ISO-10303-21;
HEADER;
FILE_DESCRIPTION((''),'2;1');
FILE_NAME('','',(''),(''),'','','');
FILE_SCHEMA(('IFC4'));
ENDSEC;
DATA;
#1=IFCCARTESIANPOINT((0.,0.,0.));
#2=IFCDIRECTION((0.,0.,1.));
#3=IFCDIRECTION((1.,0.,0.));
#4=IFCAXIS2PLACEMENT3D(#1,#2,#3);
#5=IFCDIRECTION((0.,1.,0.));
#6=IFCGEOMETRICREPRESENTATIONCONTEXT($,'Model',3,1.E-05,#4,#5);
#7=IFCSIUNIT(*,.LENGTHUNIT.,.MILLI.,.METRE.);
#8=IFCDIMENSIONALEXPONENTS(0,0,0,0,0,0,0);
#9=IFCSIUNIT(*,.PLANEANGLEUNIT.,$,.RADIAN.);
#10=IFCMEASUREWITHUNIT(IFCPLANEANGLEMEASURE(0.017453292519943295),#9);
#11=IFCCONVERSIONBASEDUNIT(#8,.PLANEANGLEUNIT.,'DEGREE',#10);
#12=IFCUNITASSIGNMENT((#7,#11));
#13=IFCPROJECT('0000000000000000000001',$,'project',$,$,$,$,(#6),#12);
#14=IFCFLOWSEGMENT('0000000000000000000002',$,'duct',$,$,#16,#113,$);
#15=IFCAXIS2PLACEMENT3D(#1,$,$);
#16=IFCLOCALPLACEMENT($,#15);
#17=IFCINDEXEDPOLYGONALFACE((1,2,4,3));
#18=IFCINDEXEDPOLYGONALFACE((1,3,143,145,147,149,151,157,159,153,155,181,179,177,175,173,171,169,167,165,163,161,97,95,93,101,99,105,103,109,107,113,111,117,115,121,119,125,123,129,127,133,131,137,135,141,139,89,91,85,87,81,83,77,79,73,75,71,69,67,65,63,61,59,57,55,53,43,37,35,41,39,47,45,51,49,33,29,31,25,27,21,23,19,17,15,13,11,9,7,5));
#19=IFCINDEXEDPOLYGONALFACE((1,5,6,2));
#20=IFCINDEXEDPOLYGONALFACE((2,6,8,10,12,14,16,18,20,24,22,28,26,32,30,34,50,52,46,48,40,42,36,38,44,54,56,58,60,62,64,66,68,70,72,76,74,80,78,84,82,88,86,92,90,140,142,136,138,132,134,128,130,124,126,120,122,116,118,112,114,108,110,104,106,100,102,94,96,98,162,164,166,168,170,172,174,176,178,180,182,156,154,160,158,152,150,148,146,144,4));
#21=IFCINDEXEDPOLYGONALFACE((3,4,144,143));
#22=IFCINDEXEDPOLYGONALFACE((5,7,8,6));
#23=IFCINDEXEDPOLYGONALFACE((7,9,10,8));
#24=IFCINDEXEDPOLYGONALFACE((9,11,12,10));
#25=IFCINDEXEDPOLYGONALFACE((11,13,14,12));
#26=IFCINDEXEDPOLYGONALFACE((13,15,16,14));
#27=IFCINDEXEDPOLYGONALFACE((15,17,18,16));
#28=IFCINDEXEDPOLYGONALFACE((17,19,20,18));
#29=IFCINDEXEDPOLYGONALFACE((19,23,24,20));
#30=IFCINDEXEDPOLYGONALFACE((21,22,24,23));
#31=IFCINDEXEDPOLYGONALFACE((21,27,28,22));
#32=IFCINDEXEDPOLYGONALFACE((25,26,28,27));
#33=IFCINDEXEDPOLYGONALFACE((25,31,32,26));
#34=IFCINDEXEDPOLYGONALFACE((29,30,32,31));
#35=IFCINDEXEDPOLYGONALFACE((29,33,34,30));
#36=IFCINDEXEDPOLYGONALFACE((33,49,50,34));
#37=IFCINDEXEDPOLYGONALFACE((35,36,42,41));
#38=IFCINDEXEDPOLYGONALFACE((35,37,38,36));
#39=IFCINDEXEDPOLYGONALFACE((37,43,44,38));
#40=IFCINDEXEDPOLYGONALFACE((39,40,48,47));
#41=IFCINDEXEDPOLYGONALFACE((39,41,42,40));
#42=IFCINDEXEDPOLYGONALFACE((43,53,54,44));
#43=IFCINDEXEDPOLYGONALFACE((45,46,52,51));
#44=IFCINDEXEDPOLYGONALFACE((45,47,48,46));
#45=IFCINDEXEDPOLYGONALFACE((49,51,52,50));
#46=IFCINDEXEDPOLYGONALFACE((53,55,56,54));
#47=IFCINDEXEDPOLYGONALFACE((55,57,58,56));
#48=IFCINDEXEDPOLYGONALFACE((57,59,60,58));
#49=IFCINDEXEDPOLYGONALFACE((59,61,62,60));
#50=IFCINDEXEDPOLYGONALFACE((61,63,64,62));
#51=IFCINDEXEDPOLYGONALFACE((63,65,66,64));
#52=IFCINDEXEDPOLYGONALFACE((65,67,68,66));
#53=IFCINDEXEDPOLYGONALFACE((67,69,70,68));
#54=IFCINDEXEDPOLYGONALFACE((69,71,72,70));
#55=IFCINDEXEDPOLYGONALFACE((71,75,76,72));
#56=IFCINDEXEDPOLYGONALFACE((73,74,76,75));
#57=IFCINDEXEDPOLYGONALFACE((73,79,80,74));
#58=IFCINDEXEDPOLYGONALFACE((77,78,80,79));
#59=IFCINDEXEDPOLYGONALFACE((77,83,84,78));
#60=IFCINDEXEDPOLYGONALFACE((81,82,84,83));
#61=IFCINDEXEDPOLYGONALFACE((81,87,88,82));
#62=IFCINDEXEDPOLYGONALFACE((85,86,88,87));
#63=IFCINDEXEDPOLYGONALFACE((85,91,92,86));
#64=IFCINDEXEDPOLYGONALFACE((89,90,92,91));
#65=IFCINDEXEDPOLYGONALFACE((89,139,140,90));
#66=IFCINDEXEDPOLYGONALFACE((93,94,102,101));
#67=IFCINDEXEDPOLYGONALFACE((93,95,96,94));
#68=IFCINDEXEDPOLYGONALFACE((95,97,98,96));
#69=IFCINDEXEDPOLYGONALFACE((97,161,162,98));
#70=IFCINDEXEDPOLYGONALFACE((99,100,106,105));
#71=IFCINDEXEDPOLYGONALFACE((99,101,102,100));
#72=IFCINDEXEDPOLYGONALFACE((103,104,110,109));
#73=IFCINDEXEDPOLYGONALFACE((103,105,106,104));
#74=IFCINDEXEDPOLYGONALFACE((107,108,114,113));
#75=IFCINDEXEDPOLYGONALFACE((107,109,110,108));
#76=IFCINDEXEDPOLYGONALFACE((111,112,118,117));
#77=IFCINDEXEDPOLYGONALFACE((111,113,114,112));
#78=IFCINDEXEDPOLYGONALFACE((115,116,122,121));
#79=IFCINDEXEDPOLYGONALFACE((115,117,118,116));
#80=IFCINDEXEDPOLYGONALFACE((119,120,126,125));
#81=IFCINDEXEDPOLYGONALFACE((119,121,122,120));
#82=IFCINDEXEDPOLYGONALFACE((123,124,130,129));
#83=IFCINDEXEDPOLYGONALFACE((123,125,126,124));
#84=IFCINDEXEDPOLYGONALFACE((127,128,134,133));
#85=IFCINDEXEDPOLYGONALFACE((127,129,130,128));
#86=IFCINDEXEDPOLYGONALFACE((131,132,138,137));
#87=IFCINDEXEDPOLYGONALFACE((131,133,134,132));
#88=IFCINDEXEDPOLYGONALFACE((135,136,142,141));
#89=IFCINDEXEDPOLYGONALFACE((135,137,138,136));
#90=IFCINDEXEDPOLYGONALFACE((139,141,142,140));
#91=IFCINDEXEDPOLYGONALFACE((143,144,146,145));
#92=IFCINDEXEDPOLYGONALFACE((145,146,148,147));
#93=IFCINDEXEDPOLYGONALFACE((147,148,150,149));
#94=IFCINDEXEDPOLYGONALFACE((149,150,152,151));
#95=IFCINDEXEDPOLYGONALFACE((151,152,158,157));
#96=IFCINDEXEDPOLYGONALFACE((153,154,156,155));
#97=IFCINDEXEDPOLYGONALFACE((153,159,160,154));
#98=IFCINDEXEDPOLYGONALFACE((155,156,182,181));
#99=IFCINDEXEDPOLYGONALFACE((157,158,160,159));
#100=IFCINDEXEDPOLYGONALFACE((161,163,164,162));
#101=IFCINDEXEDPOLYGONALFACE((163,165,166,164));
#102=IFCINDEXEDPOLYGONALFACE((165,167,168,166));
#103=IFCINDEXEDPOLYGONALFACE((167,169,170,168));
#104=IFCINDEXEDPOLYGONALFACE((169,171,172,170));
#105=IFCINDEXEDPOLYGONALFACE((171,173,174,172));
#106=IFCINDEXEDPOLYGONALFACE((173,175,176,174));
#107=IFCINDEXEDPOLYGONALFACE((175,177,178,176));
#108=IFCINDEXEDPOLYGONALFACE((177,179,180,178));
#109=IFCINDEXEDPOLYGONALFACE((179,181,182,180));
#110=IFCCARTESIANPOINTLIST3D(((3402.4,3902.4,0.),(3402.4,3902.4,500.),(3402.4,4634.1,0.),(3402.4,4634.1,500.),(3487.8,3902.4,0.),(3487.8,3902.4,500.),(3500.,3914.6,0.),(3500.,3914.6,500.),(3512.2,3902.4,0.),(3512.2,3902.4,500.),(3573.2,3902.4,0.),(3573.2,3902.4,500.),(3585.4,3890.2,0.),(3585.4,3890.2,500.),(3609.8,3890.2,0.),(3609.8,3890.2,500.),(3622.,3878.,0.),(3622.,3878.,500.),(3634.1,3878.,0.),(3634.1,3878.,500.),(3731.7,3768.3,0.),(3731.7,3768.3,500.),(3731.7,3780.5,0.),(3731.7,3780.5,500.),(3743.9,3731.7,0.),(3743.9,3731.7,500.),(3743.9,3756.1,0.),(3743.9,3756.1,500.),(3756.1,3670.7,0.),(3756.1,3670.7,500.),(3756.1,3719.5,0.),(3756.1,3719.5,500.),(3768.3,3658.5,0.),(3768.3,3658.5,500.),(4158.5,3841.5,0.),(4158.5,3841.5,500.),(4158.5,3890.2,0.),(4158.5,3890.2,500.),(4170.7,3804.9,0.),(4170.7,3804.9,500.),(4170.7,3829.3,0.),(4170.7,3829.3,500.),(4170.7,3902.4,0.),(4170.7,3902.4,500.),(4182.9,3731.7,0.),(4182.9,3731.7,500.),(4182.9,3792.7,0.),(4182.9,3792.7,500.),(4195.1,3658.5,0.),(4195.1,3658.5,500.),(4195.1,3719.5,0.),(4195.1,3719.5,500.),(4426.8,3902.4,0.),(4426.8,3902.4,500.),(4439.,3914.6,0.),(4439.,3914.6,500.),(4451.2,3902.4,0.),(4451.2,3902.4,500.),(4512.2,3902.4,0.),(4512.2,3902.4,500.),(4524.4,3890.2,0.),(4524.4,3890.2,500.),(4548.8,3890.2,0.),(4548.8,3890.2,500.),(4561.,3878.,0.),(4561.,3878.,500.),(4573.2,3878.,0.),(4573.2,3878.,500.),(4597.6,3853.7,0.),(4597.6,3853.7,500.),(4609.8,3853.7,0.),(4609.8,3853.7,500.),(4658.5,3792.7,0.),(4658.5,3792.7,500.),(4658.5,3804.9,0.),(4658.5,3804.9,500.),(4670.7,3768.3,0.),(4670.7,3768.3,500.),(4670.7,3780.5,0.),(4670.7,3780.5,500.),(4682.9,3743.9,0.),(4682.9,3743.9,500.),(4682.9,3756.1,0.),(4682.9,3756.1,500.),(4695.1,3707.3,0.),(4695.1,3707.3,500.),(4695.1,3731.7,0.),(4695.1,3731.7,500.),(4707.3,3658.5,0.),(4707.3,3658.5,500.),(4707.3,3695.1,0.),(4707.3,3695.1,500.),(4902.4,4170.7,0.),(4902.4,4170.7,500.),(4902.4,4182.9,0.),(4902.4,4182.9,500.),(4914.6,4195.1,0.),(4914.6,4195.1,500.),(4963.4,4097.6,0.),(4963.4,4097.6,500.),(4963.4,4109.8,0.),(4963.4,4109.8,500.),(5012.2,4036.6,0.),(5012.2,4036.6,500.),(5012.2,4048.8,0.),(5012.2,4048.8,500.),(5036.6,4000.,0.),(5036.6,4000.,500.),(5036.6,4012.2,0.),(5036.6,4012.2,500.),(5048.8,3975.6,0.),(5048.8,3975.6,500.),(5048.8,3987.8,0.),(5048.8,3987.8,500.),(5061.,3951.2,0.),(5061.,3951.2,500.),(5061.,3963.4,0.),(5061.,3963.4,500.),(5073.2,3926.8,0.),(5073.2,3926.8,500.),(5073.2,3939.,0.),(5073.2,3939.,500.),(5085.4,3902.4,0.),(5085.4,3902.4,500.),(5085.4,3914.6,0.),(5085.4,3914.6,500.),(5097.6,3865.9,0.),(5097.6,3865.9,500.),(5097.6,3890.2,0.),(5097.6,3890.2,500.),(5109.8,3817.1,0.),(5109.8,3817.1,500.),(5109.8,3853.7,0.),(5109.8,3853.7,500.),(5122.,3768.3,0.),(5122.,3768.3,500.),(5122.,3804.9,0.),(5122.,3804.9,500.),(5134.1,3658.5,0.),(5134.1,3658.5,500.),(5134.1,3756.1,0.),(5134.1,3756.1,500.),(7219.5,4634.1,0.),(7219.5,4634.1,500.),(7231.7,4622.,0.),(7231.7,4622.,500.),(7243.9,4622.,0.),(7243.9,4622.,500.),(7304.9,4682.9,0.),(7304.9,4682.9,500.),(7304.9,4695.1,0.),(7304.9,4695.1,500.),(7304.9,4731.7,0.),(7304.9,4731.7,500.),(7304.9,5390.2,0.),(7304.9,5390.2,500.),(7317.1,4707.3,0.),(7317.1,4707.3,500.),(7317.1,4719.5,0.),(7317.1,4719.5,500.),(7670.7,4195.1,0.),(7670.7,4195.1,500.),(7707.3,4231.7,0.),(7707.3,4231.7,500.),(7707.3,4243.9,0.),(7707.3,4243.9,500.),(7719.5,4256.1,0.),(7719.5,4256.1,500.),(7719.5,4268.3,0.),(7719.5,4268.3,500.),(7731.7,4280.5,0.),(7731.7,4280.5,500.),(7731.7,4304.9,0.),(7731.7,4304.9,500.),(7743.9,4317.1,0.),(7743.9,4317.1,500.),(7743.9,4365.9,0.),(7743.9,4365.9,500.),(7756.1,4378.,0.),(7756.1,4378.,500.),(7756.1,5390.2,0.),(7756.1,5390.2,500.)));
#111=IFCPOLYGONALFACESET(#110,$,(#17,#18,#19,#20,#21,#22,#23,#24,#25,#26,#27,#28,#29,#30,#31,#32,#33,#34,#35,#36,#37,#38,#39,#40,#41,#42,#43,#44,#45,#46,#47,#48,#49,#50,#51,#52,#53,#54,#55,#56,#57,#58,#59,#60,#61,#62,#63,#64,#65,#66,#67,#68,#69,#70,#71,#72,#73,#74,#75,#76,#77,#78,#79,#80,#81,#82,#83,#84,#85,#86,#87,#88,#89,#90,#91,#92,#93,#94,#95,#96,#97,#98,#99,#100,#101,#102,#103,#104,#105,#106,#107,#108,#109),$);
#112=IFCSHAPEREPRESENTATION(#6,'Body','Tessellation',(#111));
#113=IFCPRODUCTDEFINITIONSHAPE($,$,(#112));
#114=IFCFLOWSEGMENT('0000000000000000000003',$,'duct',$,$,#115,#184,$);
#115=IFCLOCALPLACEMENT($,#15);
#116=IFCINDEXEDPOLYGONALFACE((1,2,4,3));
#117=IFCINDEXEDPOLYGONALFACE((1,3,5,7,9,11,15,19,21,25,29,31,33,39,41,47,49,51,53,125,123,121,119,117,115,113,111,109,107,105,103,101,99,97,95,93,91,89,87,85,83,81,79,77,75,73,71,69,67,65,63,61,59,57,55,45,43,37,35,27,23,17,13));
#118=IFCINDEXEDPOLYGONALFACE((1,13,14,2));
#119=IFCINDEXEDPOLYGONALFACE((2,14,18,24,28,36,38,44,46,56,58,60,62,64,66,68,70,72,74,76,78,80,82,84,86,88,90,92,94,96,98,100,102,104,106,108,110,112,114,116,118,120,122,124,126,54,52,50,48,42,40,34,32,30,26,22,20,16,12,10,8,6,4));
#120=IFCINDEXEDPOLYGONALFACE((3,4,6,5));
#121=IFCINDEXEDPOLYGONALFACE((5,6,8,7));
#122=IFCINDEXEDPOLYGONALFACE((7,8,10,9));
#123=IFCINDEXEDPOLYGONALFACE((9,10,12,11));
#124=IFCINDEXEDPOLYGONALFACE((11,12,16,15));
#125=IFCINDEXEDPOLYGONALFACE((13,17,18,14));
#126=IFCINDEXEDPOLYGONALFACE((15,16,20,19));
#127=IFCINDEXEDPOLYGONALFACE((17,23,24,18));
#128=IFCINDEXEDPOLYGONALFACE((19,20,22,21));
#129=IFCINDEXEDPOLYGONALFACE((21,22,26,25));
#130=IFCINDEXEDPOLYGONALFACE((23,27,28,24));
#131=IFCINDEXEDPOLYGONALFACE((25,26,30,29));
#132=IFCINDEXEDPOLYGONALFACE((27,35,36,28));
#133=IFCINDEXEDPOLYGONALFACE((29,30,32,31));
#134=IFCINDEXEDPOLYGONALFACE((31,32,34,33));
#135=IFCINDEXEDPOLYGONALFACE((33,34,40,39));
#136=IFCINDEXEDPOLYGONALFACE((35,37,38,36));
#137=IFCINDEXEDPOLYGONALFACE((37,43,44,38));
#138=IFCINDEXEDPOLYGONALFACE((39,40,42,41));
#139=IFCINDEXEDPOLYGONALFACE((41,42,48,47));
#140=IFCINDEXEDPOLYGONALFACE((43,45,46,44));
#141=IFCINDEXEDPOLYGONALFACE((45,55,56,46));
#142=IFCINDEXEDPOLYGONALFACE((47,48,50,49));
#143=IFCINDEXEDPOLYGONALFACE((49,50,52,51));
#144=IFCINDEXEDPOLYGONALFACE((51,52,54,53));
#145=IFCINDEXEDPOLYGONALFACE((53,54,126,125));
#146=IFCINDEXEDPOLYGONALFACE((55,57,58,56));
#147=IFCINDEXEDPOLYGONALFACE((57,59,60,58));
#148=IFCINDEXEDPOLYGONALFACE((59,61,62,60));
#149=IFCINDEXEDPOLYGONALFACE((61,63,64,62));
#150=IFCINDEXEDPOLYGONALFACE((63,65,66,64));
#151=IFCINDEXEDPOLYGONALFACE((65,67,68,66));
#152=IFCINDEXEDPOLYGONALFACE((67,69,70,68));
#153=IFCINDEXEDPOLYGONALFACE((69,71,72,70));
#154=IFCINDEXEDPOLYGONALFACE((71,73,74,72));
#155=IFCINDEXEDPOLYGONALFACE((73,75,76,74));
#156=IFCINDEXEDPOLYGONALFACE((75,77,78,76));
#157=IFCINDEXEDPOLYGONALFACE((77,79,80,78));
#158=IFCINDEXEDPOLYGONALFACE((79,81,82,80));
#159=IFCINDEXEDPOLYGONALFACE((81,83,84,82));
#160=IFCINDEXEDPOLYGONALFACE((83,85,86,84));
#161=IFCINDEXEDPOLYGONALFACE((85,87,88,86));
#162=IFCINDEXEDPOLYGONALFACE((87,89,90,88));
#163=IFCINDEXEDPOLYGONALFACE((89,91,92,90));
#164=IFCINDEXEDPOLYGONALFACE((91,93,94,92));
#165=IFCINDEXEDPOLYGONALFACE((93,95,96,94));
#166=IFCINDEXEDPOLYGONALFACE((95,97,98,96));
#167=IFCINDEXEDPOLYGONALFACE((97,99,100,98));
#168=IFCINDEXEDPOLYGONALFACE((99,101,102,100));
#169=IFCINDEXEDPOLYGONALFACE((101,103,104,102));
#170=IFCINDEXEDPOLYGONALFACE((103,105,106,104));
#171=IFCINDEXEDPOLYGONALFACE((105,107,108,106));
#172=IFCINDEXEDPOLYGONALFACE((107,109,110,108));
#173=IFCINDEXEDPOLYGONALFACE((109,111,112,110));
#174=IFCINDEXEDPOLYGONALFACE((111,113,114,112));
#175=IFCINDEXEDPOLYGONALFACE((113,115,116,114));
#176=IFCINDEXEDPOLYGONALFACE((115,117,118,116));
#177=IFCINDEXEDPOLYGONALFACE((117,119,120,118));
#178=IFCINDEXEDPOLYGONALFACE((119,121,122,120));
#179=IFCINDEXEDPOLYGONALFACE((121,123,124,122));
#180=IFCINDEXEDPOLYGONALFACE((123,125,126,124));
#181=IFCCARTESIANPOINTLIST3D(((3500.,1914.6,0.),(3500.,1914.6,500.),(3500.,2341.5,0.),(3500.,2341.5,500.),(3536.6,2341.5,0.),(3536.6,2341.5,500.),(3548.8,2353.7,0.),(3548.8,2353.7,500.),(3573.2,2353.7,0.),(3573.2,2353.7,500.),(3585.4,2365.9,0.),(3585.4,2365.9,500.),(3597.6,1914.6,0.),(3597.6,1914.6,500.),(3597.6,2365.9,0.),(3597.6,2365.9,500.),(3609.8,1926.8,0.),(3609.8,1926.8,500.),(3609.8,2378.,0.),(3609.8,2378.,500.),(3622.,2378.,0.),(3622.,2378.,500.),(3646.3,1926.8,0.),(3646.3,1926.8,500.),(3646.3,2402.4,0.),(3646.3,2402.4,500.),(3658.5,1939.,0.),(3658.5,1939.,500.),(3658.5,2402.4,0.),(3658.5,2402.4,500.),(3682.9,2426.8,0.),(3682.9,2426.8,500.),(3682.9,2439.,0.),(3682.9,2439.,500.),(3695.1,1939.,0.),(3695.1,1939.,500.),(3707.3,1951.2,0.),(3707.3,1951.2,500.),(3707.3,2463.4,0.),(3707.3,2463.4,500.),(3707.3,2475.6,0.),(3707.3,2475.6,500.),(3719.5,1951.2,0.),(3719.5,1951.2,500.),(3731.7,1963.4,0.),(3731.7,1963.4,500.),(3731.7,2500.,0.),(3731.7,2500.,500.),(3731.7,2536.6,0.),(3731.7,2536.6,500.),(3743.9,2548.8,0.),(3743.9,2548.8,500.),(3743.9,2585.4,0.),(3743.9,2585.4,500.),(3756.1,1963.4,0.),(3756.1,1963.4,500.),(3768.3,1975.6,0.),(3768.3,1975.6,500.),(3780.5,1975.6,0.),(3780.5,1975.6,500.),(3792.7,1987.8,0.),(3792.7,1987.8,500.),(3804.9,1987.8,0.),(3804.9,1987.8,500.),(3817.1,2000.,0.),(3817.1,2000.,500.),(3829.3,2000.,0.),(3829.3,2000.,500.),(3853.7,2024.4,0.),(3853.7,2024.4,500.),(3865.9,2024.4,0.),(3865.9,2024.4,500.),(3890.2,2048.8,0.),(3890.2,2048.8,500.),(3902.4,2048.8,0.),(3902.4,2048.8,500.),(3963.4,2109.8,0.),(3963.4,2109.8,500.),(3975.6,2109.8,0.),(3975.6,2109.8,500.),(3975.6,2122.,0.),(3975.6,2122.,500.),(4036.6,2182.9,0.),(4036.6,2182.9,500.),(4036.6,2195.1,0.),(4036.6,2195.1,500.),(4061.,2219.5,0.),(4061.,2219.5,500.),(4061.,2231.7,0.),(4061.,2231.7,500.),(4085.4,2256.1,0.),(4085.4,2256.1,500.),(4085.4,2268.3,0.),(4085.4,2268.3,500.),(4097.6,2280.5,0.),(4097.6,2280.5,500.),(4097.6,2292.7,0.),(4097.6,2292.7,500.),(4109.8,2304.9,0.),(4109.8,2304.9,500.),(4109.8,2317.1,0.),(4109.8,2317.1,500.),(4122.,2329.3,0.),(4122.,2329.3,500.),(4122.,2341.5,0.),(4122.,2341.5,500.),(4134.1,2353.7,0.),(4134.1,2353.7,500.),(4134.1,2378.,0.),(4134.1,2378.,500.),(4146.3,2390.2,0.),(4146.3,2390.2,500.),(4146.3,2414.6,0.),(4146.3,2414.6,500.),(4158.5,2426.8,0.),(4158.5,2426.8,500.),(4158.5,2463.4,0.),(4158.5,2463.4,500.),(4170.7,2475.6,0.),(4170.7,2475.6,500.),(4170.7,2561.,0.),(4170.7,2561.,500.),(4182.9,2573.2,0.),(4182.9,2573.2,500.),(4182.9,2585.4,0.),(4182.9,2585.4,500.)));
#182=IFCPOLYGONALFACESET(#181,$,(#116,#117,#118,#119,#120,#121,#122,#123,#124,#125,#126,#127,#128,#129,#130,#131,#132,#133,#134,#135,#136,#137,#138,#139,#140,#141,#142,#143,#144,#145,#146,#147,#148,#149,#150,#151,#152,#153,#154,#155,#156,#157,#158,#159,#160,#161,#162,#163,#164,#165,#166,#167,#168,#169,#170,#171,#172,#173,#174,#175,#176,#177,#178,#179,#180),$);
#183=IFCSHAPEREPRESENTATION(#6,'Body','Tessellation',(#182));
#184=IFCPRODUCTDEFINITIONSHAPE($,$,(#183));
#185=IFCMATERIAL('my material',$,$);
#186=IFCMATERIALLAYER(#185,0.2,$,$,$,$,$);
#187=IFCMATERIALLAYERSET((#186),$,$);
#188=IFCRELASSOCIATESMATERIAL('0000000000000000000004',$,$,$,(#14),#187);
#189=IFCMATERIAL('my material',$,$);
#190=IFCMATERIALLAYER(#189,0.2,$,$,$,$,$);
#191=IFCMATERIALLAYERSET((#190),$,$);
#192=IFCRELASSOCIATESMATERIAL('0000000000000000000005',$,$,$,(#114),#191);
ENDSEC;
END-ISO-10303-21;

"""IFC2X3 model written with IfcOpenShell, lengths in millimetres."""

from ifc_helpers import new_model, entity, si_unit, converted_unit, direction, origin_with_axes, place, context, project, polyline, outline, extrude, material, layer, layer_set, layer_usage, element, save


model = new_model("IFC2X3")

# Units and contexts
model_context = context("Model", 3, precision=1e-05, world=origin_with_axes(), true_north=direction((0.0, 1.0, 0.0)))
ifc_project = project(units=[si_unit("LENGTHUNIT", "METRE", prefix="MILLI"), converted_unit("PLANEANGLEUNIT", "DEGREE", entity("IfcPlaneAngleMeasure", 0.017453292519943295), si_unit("PLANEANGLEUNIT", "RADIAN"), dimensions=[0, 0, 0, 0, 0, 0, 0])], contexts=[model_context])

# Flow segments
ifc_material_1 = material(Name="my material")
ifc_layer_1 = layer(ifc_material_1, 0.2)
ifc_layer_set_1 = layer_set([ifc_layer_1])
ifc_layer_usage_1 = layer_usage(ifc_layer_set_1, "AXIS2", "POSITIVE", -0.1)
flow_segment_1_placement = place(None, origin_with_axes())
element("IfcFlowSegment", 1, at=flow_segment_1_placement, material=ifc_layer_usage_1, Name="duct", context=model_context, shape_type="SweptSolid", body=[
    extrude(outline(polyline([(3402.4, 3902.4), (3487.8, 3902.4), (3500.0, 3914.6), (3512.2, 3902.4), (3573.2, 3902.4), (3585.4, 3890.2), (3609.8, 3890.2), (3622.0, 3878.0), (3634.1, 3878.0), (3731.7, 3780.5), (3731.7, 3768.3), (3743.9, 3756.1), (3743.9, 3731.7), (3756.1, 3719.5), (3756.1, 3670.7), (3768.3, 3658.5), (4195.1, 3658.5), (4195.1, 3719.5), (4182.9, 3731.7), (4182.9, 3792.7), (4170.7, 3804.9), (4170.7, 3829.3), (4158.5, 3841.5), (4158.5, 3890.2), (4170.7, 3902.4), (4426.8, 3902.4), (4439.0, 3914.6), (4451.2, 3902.4), (4512.2, 3902.4), (4524.4, 3890.2), (4548.8, 3890.2), (4561.0, 3878.0), (4573.2, 3878.0), (4597.6, 3853.7), (4609.8, 3853.7), (4658.5, 3804.9), (4658.5, 3792.7), (4670.7, 3780.5), (4670.7, 3768.3), (4682.9, 3756.1), (4682.9, 3743.9), (4695.1, 3731.7), (4695.1, 3707.3), (4707.3, 3695.1), (4707.3, 3658.5), (5134.1, 3658.5), (5134.1, 3756.1), (5122.0, 3768.3), (5122.0, 3804.9), (5109.8, 3817.1), (5109.8, 3853.7), (5097.6, 3865.9), (5097.6, 3890.2), (5085.4, 3902.4), (5085.4, 3914.6), (5073.2, 3926.8), (5073.2, 3939.0), (5061.0, 3951.2), (5061.0, 3963.4), (5048.8, 3975.6), (5048.8, 3987.8), (5036.6, 4000.0), (5036.6, 4012.2), (5012.2, 4036.6), (5012.2, 4048.8), (4963.4, 4097.6), (4963.4, 4109.8), (4902.4, 4170.7), (4902.4, 4182.9), (4914.6, 4195.1), (7670.7, 4195.1), (7707.3, 4231.7), (7707.3, 4243.9), (7719.5, 4256.1), (7719.5, 4268.3), (7731.7, 4280.5), (7731.7, 4304.9), (7743.9, 4317.1), (7743.9, 4365.9), (7756.1, 4378.0), (7756.1, 5390.2), (7304.9, 5390.2), (7304.9, 4731.7), (7317.1, 4719.5), (7317.1, 4707.3), (7304.9, 4695.1), (7304.9, 4682.9), (7243.9, 4622.0), (7231.7, 4622.0), (7219.5, 4634.1), (3402.4, 4634.1), (3402.4, 3902.4)])), origin_with_axes(), (0.0, 0.0, 1.0), 500.0),
])
ifc_material_2 = material(Name="my material")
ifc_layer_2 = layer(ifc_material_2, 0.2)
ifc_layer_set_2 = layer_set([ifc_layer_2])
ifc_layer_usage_2 = layer_usage(ifc_layer_set_2, "AXIS2", "POSITIVE", -0.1)
flow_segment_2_placement = place(None, origin_with_axes())
element("IfcFlowSegment", 2, at=flow_segment_2_placement, material=ifc_layer_usage_2, Name="duct", context=model_context, shape_type="SweptSolid", body=[
    extrude(outline(polyline([(3500.0, 1914.6), (3597.6, 1914.6), (3609.8, 1926.8), (3646.3, 1926.8), (3658.5, 1939.0), (3695.1, 1939.0), (3707.3, 1951.2), (3719.5, 1951.2), (3731.7, 1963.4), (3756.1, 1963.4), (3768.3, 1975.6), (3780.5, 1975.6), (3792.7, 1987.8), (3804.9, 1987.8), (3817.1, 2000.0), (3829.3, 2000.0), (3853.7, 2024.4), (3865.9, 2024.4), (3890.2, 2048.8), (3902.4, 2048.8), (3963.4, 2109.8), (3975.6, 2109.8), (3975.6, 2122.0), (4036.6, 2182.9), (4036.6, 2195.1), (4061.0, 2219.5), (4061.0, 2231.7), (4085.4, 2256.1), (4085.4, 2268.3), (4097.6, 2280.5), (4097.6, 2292.7), (4109.8, 2304.9), (4109.8, 2317.1), (4122.0, 2329.3), (4122.0, 2341.5), (4134.1, 2353.7), (4134.1, 2378.0), (4146.3, 2390.2), (4146.3, 2414.6), (4158.5, 2426.8), (4158.5, 2463.4), (4170.7, 2475.6), (4170.7, 2561.0), (4182.9, 2573.2), (4182.9, 2585.4), (3743.9, 2585.4), (3743.9, 2548.8), (3731.7, 2536.6), (3731.7, 2500.0), (3707.3, 2475.6), (3707.3, 2463.4), (3682.9, 2439.0), (3682.9, 2426.8), (3658.5, 2402.4), (3646.3, 2402.4), (3622.0, 2378.0), (3609.8, 2378.0), (3597.6, 2365.9), (3585.4, 2365.9), (3573.2, 2353.7), (3548.8, 2353.7), (3536.6, 2341.5), (3500.0, 2341.5), (3500.0, 1914.6)])), origin_with_axes(), (0.0, 0.0, 1.0), 500.0),
])

save(model, "model.ifc")
